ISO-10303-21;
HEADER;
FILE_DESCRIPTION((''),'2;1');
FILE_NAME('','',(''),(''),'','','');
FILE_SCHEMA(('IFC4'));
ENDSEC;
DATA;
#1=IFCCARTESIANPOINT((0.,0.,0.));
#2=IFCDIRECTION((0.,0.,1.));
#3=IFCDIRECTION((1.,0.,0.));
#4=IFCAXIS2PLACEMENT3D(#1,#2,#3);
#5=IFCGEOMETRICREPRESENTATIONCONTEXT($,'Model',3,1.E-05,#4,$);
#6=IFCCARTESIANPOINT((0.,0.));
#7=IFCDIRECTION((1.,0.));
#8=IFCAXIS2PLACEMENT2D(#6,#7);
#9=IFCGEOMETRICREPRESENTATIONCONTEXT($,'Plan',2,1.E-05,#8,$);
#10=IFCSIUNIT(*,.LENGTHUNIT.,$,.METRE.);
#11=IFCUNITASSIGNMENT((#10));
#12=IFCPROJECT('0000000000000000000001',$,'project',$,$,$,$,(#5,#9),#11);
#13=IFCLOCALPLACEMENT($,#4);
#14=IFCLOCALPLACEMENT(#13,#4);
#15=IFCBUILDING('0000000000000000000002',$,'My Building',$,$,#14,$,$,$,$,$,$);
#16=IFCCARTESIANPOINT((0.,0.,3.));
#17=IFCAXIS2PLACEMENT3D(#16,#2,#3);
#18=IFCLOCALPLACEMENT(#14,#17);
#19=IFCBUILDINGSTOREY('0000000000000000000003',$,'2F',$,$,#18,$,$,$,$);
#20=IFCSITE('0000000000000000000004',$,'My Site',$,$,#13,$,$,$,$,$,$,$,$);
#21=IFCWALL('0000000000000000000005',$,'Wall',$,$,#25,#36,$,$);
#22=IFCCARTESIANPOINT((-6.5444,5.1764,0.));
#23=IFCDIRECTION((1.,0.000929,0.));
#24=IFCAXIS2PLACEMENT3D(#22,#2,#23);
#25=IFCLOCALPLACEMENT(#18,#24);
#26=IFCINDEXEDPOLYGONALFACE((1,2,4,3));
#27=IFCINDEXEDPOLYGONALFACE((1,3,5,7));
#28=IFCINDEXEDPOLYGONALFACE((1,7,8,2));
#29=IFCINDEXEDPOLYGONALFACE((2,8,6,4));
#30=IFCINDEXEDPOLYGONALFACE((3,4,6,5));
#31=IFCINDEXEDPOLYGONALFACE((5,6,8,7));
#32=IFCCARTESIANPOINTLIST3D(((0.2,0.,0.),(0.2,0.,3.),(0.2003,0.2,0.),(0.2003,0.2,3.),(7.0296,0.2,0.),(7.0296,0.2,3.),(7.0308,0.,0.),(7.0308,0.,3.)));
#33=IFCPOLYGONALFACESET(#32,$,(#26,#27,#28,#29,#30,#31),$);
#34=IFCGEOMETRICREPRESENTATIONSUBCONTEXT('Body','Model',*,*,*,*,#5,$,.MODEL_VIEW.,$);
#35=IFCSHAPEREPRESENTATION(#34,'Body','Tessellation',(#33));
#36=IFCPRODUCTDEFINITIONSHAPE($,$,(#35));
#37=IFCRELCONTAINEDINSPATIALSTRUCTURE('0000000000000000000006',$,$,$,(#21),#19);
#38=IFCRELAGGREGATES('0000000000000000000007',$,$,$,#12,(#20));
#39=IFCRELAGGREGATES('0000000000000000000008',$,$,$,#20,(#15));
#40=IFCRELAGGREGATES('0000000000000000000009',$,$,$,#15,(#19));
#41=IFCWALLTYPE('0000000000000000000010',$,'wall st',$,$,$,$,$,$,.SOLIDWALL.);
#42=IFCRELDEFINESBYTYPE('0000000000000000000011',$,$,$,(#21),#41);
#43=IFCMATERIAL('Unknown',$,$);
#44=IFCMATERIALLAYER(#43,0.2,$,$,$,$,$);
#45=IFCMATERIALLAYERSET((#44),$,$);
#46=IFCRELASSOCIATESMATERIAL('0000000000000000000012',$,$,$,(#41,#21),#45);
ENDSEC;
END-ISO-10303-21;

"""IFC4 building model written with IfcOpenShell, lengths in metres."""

from ifc_helpers import new_model, si_unit, frame, origin_with_axes, origin_2d_with_axis, place, context, subcontext, project, spatial, line, indexed_curve, outline, extrude, material, layer, layer_set, layer_usage, type_object, element, save


model = new_model("IFC4")

# Units and contexts
model_context = context("Model", 3, precision=1e-05, world=origin_with_axes())
plan_context = context("Plan", 2, precision=1e-05, world=origin_2d_with_axis())
body_context_1 = subcontext(model_context, "Body", "Model", "MODEL_VIEW")
ifc_project = project(units=[si_unit("LENGTHUNIT", "METRE")], contexts=[model_context, plan_context])

# Site, building, storey
site_placement = place(None, origin_with_axes())
site = spatial("IfcSite", under=ifc_project, at=site_placement, Name="My Site")
building_placement = place(site_placement, origin_with_axes())
building = spatial("IfcBuilding", under=site, at=building_placement, Name="My Building")
storey_placement = place(building_placement, frame((0.0, 0.0, 3.0), z_axis=(0.0, 0.0, 1.0), x_axis=(1.0, 0.0, 0.0)))
storey = spatial("IfcBuildingStorey", under=building, at=storey_placement, Name="2F")

# Shared definitions
ifc_material = material(Name="Unknown")

# Shared definitions
ifc_layer_1 = layer(ifc_material, 0.2)
ifc_layer_set_1 = layer_set([ifc_layer_1])
wall_type_1 = type_object("IfcWallType", Name="wall st", PredefinedType="SOLIDWALL", material=ifc_layer_set_1)

# Wall
ifc_layer_usage_1 = layer_usage(ifc_layer_set_1, "AXIS2", "POSITIVE", 0.0)
wall_1_placement = place(storey_placement, frame((-6.5444, 5.1764, 0.0), z_axis=(0.0, 0.0, 1.0), x_axis=(1.0, 0.000929, 0.0)))
element("IfcWall", 1, at=wall_1_placement, inside=storey, type_object=wall_type_1, material=ifc_layer_usage_1, Name="Wall", context=body_context_1, shape_type="SweptSolid", body=[
    extrude(outline(indexed_curve([(0.2, 0.0), (0.2003, 0.2), (7.0296, 0.2), (7.0308, 0.0)], segments=[line(1, 2, 3, 4, 1)])), origin_with_axes(), (0.0, 0.0, 1.0), 3.0),
])

save(model, "model.ifc")
